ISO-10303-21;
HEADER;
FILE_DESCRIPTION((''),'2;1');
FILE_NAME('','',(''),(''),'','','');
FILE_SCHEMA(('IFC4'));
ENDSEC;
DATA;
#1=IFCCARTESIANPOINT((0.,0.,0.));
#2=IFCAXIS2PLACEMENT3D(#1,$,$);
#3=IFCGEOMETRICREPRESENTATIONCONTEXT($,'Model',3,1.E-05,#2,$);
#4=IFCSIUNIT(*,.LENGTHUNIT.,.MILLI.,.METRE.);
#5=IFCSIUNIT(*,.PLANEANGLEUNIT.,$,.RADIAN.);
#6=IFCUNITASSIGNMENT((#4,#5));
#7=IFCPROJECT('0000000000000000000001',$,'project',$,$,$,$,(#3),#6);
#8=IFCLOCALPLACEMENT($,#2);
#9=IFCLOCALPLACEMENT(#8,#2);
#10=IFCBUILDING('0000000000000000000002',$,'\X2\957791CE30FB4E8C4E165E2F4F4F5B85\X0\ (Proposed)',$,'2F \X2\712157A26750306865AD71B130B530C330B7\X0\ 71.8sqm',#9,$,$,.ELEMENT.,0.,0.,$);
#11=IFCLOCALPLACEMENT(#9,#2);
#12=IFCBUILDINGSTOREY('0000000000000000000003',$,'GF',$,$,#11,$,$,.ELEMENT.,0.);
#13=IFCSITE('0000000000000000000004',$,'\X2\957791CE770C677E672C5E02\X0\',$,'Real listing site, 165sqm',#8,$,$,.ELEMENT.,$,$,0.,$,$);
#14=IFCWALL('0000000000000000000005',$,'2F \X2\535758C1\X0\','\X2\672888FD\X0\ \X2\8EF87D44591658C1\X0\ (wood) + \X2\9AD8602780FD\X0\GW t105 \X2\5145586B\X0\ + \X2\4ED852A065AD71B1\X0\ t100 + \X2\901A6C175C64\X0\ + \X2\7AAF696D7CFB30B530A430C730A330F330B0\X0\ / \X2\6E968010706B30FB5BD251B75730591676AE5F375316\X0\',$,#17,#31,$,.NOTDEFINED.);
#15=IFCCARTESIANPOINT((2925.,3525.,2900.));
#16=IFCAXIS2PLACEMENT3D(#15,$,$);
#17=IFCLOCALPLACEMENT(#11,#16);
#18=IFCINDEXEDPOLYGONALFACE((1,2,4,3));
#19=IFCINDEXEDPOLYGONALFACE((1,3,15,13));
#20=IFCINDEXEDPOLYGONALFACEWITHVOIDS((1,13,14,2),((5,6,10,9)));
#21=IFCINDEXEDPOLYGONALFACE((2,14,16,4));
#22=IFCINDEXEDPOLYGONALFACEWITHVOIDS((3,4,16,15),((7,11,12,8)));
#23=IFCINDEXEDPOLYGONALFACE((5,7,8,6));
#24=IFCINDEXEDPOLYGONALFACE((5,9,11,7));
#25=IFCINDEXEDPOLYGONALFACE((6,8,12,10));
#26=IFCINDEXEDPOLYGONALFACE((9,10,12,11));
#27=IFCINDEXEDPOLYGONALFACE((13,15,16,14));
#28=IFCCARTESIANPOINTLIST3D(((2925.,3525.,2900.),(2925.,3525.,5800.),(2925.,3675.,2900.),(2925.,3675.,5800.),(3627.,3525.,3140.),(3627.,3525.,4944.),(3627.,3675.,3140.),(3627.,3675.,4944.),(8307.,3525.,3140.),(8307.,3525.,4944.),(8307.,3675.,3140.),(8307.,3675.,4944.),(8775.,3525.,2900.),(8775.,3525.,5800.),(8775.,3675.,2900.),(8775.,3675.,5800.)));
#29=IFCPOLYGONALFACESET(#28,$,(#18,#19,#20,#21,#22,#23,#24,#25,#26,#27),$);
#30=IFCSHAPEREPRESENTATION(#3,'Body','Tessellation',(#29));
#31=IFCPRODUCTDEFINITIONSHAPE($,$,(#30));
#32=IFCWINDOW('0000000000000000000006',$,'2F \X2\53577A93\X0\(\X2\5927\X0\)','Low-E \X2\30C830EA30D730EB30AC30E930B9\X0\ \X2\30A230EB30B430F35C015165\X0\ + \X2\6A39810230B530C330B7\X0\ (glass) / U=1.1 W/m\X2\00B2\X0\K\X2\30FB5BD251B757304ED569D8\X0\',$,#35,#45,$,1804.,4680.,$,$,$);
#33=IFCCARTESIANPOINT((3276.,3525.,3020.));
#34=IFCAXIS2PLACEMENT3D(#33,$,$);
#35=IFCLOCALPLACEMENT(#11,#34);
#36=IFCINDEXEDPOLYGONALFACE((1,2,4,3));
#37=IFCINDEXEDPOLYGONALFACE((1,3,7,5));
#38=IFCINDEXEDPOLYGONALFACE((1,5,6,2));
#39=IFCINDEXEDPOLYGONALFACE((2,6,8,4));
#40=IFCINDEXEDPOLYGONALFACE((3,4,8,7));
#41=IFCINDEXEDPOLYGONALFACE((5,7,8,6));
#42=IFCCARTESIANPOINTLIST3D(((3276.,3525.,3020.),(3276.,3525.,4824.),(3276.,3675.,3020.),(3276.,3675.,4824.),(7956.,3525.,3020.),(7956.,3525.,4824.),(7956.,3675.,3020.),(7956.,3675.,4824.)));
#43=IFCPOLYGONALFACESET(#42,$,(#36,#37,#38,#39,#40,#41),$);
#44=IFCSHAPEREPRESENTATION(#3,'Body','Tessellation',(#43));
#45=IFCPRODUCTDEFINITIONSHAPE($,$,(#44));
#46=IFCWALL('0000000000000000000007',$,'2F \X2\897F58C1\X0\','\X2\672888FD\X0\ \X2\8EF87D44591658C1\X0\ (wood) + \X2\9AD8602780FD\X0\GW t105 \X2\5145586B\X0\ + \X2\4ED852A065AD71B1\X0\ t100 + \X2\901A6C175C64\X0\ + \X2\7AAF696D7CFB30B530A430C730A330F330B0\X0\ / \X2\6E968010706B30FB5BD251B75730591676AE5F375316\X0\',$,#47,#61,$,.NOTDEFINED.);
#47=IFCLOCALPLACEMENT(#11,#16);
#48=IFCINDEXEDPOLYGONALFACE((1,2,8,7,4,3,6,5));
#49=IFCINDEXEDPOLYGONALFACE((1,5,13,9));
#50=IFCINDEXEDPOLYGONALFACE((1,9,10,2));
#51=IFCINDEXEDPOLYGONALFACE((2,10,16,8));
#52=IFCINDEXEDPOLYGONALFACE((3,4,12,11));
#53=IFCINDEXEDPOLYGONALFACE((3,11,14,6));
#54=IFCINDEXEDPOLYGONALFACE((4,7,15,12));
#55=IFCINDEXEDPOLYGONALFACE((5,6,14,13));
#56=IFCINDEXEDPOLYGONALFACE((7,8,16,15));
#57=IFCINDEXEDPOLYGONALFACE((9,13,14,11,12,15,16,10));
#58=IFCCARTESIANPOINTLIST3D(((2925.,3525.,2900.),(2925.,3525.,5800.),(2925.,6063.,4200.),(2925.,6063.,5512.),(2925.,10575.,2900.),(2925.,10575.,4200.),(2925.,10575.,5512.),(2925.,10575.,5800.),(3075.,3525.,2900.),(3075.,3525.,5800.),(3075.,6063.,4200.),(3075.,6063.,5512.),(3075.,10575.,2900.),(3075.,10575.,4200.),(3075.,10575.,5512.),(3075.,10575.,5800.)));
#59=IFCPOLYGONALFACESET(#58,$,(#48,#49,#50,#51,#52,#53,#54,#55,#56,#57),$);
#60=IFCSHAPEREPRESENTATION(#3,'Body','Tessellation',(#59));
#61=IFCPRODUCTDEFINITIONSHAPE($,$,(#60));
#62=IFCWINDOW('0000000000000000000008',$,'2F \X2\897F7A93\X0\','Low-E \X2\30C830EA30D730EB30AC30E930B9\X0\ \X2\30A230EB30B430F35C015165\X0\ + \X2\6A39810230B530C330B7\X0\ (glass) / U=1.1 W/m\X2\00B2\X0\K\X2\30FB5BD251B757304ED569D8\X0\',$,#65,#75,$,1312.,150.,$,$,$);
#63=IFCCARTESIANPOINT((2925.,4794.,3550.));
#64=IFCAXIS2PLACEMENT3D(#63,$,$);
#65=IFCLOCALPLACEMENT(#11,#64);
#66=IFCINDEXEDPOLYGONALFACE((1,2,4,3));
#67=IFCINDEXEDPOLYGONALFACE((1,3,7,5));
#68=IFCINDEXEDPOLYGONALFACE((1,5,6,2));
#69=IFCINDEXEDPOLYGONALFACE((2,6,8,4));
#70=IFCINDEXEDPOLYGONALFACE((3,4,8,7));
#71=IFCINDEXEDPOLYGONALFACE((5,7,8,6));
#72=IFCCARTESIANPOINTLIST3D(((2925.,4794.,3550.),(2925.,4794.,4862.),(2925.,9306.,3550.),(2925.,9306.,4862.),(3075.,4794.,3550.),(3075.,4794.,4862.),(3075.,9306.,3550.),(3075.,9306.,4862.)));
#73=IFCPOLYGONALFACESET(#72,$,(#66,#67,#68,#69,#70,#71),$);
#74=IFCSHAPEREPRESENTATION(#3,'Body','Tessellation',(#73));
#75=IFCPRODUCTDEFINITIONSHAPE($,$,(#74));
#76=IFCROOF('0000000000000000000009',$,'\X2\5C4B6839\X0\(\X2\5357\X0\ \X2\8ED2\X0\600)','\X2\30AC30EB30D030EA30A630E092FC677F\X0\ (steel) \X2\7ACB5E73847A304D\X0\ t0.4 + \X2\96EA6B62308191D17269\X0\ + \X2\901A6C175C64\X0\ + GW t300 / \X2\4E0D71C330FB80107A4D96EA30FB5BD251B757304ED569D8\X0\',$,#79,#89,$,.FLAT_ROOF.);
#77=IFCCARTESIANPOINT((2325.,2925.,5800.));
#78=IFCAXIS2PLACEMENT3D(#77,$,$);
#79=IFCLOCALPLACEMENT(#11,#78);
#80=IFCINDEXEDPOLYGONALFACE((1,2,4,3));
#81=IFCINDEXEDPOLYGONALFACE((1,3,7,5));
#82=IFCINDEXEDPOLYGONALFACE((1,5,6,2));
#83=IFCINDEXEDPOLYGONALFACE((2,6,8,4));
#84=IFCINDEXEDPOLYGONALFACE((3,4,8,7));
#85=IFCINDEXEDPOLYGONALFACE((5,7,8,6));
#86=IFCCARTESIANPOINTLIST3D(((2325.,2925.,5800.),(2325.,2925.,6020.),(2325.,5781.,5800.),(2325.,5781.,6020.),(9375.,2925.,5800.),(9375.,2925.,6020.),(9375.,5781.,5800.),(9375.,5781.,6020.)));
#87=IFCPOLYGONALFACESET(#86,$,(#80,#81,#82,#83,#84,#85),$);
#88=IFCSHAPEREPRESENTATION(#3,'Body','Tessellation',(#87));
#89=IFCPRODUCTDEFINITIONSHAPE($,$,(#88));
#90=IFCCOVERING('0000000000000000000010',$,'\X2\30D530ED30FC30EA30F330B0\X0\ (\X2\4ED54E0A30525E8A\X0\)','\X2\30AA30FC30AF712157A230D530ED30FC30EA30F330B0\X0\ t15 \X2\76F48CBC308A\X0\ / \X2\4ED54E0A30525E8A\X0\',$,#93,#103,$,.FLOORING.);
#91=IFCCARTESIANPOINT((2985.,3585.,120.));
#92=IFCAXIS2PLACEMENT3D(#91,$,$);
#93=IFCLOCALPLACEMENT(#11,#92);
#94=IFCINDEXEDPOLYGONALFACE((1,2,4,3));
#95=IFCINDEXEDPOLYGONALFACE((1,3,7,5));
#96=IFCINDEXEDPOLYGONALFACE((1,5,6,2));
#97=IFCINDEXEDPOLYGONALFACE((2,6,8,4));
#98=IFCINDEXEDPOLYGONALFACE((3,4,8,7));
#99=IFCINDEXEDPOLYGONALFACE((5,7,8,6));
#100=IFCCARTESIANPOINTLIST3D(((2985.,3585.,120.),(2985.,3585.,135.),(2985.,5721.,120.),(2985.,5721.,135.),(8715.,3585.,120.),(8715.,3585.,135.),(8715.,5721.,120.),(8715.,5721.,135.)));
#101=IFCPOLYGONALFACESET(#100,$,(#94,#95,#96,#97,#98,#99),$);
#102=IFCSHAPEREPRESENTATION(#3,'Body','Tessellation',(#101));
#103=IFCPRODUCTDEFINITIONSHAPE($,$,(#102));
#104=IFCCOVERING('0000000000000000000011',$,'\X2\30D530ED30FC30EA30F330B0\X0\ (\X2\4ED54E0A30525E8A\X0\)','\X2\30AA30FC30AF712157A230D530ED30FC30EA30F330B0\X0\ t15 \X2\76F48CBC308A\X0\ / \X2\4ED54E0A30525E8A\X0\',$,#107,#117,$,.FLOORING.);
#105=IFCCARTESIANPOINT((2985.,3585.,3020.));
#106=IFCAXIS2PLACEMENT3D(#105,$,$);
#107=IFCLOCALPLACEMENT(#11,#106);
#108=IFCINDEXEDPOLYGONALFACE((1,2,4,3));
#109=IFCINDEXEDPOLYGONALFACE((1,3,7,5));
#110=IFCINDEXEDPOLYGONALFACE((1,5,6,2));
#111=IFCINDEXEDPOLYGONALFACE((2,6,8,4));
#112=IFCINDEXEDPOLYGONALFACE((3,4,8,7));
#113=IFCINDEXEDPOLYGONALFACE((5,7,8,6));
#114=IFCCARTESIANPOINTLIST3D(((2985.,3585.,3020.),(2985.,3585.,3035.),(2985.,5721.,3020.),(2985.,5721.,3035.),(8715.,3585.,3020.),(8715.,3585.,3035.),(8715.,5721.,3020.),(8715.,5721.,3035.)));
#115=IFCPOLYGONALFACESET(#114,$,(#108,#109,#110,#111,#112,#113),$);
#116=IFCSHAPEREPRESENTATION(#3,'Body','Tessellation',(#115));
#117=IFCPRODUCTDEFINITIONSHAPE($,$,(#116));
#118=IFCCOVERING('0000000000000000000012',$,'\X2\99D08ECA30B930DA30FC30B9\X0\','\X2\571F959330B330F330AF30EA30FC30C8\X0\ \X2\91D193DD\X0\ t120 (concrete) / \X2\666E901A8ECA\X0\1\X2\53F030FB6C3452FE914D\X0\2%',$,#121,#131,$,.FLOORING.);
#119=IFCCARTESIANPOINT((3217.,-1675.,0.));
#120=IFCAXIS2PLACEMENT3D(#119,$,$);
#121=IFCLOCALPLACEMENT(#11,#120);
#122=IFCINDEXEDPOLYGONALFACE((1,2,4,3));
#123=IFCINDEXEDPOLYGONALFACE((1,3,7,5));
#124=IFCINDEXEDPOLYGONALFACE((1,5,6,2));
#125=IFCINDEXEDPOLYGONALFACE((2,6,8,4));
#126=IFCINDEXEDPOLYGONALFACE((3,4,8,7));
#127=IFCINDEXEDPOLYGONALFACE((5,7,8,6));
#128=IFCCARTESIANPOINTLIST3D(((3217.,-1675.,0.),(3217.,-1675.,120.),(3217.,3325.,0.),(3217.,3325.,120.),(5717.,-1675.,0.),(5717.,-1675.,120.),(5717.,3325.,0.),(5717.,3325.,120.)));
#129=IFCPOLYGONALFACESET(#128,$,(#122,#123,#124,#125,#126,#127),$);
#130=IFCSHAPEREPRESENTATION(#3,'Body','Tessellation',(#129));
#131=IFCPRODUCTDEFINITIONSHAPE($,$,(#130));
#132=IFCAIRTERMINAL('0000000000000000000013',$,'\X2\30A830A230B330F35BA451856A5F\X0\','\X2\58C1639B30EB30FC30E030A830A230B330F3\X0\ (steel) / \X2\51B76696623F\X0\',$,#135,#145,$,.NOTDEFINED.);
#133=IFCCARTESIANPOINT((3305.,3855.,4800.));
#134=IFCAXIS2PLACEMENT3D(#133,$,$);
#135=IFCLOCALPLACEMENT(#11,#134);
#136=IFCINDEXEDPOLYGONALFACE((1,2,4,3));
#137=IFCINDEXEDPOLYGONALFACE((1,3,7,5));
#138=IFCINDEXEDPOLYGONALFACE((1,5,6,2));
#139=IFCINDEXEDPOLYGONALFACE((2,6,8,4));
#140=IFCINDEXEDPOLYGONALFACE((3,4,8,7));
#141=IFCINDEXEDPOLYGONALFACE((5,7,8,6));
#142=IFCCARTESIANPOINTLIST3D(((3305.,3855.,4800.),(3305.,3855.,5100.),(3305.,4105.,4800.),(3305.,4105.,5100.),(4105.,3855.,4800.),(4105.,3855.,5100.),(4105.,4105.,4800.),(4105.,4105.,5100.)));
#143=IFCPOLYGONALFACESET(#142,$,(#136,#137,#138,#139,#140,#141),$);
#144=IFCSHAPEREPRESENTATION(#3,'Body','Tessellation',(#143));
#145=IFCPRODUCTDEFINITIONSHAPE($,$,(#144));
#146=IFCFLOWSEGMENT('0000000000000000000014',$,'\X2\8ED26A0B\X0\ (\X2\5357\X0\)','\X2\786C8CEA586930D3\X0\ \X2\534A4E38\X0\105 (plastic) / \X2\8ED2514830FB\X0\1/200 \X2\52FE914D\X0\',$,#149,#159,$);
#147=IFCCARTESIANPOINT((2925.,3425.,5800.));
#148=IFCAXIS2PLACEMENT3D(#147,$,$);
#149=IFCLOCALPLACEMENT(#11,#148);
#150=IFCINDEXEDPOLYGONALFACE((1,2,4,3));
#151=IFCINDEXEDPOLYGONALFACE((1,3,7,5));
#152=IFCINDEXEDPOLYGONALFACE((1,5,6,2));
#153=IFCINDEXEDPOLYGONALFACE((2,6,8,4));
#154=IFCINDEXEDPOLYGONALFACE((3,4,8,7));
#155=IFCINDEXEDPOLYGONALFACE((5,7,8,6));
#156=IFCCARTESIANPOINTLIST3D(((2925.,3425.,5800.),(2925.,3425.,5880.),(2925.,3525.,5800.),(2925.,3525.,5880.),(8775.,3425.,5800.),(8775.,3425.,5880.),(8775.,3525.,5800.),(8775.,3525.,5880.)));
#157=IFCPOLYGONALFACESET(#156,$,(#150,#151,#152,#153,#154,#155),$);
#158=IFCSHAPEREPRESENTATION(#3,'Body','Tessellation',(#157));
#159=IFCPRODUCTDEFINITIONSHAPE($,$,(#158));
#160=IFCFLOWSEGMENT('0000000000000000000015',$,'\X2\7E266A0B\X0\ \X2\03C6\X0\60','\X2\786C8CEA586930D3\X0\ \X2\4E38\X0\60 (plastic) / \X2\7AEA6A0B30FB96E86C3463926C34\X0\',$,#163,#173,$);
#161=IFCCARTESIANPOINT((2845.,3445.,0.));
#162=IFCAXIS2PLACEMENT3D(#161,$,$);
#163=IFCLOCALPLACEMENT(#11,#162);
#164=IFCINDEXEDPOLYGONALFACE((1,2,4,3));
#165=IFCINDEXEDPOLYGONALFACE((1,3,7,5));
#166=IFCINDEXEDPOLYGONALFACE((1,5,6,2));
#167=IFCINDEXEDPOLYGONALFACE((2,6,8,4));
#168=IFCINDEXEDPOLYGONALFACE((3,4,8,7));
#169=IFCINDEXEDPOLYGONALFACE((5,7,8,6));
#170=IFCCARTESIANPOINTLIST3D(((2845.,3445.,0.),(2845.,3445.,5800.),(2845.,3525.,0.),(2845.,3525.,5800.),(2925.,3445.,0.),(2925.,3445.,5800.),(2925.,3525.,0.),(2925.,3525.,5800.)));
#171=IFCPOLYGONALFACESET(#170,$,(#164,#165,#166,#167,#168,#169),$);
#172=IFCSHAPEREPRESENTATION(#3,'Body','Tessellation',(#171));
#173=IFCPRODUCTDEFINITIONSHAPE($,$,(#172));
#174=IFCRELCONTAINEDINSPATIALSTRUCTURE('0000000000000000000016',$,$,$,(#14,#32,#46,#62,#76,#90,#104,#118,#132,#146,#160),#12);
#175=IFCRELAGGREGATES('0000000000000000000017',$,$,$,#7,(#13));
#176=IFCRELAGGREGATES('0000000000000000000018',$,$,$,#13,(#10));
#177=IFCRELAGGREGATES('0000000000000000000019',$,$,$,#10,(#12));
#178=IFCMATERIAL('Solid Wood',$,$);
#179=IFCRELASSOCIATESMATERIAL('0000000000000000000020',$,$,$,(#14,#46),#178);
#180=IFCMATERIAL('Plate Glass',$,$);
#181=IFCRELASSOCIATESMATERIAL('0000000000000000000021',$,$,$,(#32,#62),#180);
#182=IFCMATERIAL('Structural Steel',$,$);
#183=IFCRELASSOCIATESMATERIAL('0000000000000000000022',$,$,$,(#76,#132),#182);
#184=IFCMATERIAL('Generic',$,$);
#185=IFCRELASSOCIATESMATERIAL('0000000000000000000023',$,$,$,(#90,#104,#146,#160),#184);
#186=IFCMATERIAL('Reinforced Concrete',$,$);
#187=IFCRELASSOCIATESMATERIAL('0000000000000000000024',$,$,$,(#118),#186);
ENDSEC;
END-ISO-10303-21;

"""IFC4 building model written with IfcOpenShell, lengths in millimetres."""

from ifc_helpers import new_model, si_unit, frame, frame_2d, origin, place, context, project, spatial, rectangle, extrude, material, element, fill, save


model = new_model("IFC4")

# Units and contexts
model_context = context("Model", 3, precision=1e-05, world=origin())
ifc_project = project(units=[si_unit("LENGTHUNIT", "METRE", prefix="MILLI"), si_unit("PLANEANGLEUNIT", "RADIAN")], contexts=[model_context])

# Site, building, storey
site_placement = place(None, origin())
site = spatial("IfcSite", under=ifc_project, at=site_placement, Name="長野県松本市", ObjectType="Real listing site, 165sqm", CompositionType="ELEMENT", RefElevation=0.0)
building_placement = place(site_placement, origin())
building = spatial("IfcBuilding", under=site, at=building_placement, Name="長野・二世帯住宅 (Proposed)", ObjectType="2F 無垢材と断熱サッシ 71.8sqm", CompositionType="ELEMENT", ElevationOfRefHeight=0.0, ElevationOfTerrain=0.0)
storey_placement = place(building_placement, origin())
storey = spatial("IfcBuildingStorey", under=building, at=storey_placement, Name="GF", CompositionType="ELEMENT", Elevation=0.0)

# Shared definitions
ifc_material_1 = material(Name="Solid Wood")

# Shared definitions
ifc_material_2 = material(Name="Reinforced Concrete")

# Shared definitions
ifc_material_3 = material(Name="Plate Glass")

# Walls, openings, windows
wall_1_placement = place(storey_placement, frame((2925.0, 3525.0, 2900.0)))
wall_1 = element("IfcWall", 1, at=wall_1_placement, inside=storey, material=ifc_material_1, Name="2F 南壁", Description="木製 軸組外壁 (wood) + 高性能GW t105 充填 + 付加断熱 t100 + 通気層 + 窯業系サイディング / 準耐火・寒冷地外皮強化", PredefinedType="NOTDEFINED", context=model_context, shape_type="SweptSolid", body=[
    extrude(rectangle(XDim=5850.0, YDim=150.0, at=frame_2d((2925.0, 75.0))), frame((2925.0, 3525.0, 2900.0)), (0.0, 0.0, 1.0), 2900.0),
])
opening_1_placement = place(storey_placement, frame((3276.0, 3525.0, 3020.0)))
opening_1 = element("IfcOpeningElement", 2, at=opening_1_placement, cuts=wall_1, PredefinedType="NOTDEFINED", context=model_context, shape_type="SweptSolid", body=[
    extrude(rectangle(XDim=4680.0, YDim=150.0, at=frame_2d((2340.0, 75.0))), frame((3276.0, 3525.0, 3020.0)), (0.0, 0.0, 1.0), 1804.0),
])
window_1_placement = place(storey_placement, frame((3276.0, 3525.0, 3020.0)))
window_1 = element("IfcWindow", 3, at=window_1_placement, inside=storey, material=ifc_material_3, Name="2F 南窓(大)", Description="Low-E トリプルガラス アルゴン封入 + 樹脂サッシ (glass) / U=1.1 W/m²K・寒冷地仕様", OverallHeight=1804.0, OverallWidth=4680.0, context=model_context, shape_type="SweptSolid", body=[
    extrude(rectangle(XDim=4680.0, YDim=150.0, at=frame_2d((2340.0, 75.0))), frame((3276.0, 3525.0, 3020.0)), (0.0, 0.0, 1.0), 1804.0),
])
fill(opening_1, window_1)
wall_2_placement = place(storey_placement, frame((2925.0, 3525.0, 2900.0)))
wall_2 = element("IfcWall", 4, at=wall_2_placement, inside=storey, material=ifc_material_1, Name="2F 西壁", Description="木製 軸組外壁 (wood) + 高性能GW t105 充填 + 付加断熱 t100 + 通気層 + 窯業系サイディング / 準耐火・寒冷地外皮強化", PredefinedType="NOTDEFINED", context=model_context, shape_type="SweptSolid", body=[
    extrude(rectangle(XDim=150.0, YDim=7050.0, at=frame_2d((75.0, 3525.0))), frame((2925.0, 3525.0, 2900.0)), (0.0, 0.0, 1.0), 2900.0),
])
opening_2_placement = place(storey_placement, frame((2925.0, 4794.0, 3550.0)))
opening_2 = element("IfcOpeningElement", 5, at=opening_2_placement, cuts=wall_2, PredefinedType="NOTDEFINED", context=model_context, shape_type="SweptSolid", body=[
    extrude(rectangle(XDim=150.0, YDim=4512.0, at=frame_2d((75.0, 2256.0))), frame((2925.0, 4794.0, 3550.0)), (0.0, 0.0, 1.0), 1312.0),
])
window_2_placement = place(storey_placement, frame((2925.0, 4794.0, 3550.0)))
window_2 = element("IfcWindow", 6, at=window_2_placement, inside=storey, material=ifc_material_3, Name="2F 西窓", Description="Low-E トリプルガラス アルゴン封入 + 樹脂サッシ (glass) / U=1.1 W/m²K・寒冷地仕様", OverallHeight=1312.0, OverallWidth=150.0, context=model_context, shape_type="SweptSolid", body=[
    extrude(rectangle(XDim=150.0, YDim=4512.0, at=frame_2d((75.0, 2256.0))), frame((2925.0, 4794.0, 3550.0)), (0.0, 0.0, 1.0), 1312.0),
])
fill(opening_2, window_2)

# Roof
ifc_material_4 = material(Name="Structural Steel")
for number, where, name in (
    (7, (2325.0, 2925.0, 5800.0), "屋根(南 軒600)"),
):
    element("IfcRoof", number, at=place(storey_placement, frame(where)), inside=storey, material=ifc_material_4, Name=name, Description="ガルバリウム鋼板 (steel) 立平葺き t0.4 + 雪止め金物 + 通気層 + GW t300 / 不燃・耐積雪・寒冷地仕様", PredefinedType="FLAT_ROOF", context=model_context, shape_type="SweptSolid", body=[
        extrude(rectangle(XDim=7050.0, YDim=2856.0, at=frame_2d((3525.0, 1428.0))), frame((2325.0, 2925.0, 5800.0)), (0.0, 0.0, 1.0), 220.0),
    ])

# Coverings
ifc_material_5 = material(Name="Generic")
covering_1_placement = place(storey_placement, frame((2985.0, 3585.0, 120.0)))
element("IfcCovering", 8, at=covering_1_placement, inside=storey, material=ifc_material_5, Name="フローリング (仕上げ床)", Description="オーク無垢フローリング t15 直貼り / 仕上げ床", PredefinedType="FLOORING", context=model_context, shape_type="SweptSolid", body=[
    extrude(rectangle(XDim=5730.0, YDim=2136.0, at=frame_2d((2865.0, 1068.0))), frame((2985.0, 3585.0, 120.0)), (0.0, 0.0, 1.0), 15.0),
])
covering_2_placement = place(storey_placement, frame((2985.0, 3585.0, 3020.0)))
element("IfcCovering", 9, at=covering_2_placement, inside=storey, material=ifc_material_5, Name="フローリング (仕上げ床)", Description="オーク無垢フローリング t15 直貼り / 仕上げ床", PredefinedType="FLOORING", context=model_context, shape_type="SweptSolid", body=[
    extrude(rectangle(XDim=5730.0, YDim=2136.0, at=frame_2d((2865.0, 1068.0))), frame((2985.0, 3585.0, 3020.0)), (0.0, 0.0, 1.0), 15.0),
])
covering_3_placement = place(storey_placement, frame((3217.0, -1675.0, 0.0)))
element("IfcCovering", 10, at=covering_3_placement, inside=storey, material=ifc_material_2, Name="駐車スペース", Description="土間コンクリート 金鏝 t120 (concrete) / 普通車1台・水勾配2%", PredefinedType="FLOORING", context=model_context, shape_type="SweptSolid", body=[
    extrude(rectangle(XDim=2500.0, YDim=5000.0, at=frame_2d((1250.0, 2500.0))), frame((3217.0, -1675.0, 0.0)), (0.0, 0.0, 1.0), 120.0),
])

# Air terminal
air_terminal_placement = place(storey_placement, frame((3305.0, 3855.0, 4800.0)))
element("IfcAirTerminal", 11, at=air_terminal_placement, inside=storey, material=ifc_material_4, Name="エアコン室内機", Description="壁掛ルームエアコン (steel) / 冷暖房", PredefinedType="NOTDEFINED", context=model_context, shape_type="SweptSolid", body=[
    extrude(rectangle(XDim=800.0, YDim=250.0, at=frame_2d((400.0, 125.0))), frame((3305.0, 3855.0, 4800.0)), (0.0, 0.0, 1.0), 300.0),
])

# Flow segments
flow_segment_1_placement = place(storey_placement, frame((2925.0, 3425.0, 5800.0)))
element("IfcFlowSegment", 12, at=flow_segment_1_placement, inside=storey, material=ifc_material_5, Name="軒樋 (南)", Description="硬質塩ビ 半丸105 (plastic) / 軒先・1/200 勾配", context=model_context, shape_type="SweptSolid", body=[
    extrude(rectangle(XDim=5850.0, YDim=100.0, at=frame_2d((2925.0, 50.0))), frame((2925.0, 3425.0, 5800.0)), (0.0, 0.0, 1.0), 80.0),
])
flow_segment_2_placement = place(storey_placement, frame((2845.0, 3445.0, 0.0)))
element("IfcFlowSegment", 13, at=flow_segment_2_placement, inside=storey, material=ifc_material_5, Name="縦樋 φ60", Description="硬質塩ビ 丸60 (plastic) / 竪樋・雨水排水", context=model_context, shape_type="SweptSolid", body=[
    extrude(rectangle(XDim=80.0, YDim=80.0, at=frame_2d((40.0, 40.0))), frame((2845.0, 3445.0, 0.0)), (0.0, 0.0, 1.0), 5800.0),
])

save(model, "model.ifc")
